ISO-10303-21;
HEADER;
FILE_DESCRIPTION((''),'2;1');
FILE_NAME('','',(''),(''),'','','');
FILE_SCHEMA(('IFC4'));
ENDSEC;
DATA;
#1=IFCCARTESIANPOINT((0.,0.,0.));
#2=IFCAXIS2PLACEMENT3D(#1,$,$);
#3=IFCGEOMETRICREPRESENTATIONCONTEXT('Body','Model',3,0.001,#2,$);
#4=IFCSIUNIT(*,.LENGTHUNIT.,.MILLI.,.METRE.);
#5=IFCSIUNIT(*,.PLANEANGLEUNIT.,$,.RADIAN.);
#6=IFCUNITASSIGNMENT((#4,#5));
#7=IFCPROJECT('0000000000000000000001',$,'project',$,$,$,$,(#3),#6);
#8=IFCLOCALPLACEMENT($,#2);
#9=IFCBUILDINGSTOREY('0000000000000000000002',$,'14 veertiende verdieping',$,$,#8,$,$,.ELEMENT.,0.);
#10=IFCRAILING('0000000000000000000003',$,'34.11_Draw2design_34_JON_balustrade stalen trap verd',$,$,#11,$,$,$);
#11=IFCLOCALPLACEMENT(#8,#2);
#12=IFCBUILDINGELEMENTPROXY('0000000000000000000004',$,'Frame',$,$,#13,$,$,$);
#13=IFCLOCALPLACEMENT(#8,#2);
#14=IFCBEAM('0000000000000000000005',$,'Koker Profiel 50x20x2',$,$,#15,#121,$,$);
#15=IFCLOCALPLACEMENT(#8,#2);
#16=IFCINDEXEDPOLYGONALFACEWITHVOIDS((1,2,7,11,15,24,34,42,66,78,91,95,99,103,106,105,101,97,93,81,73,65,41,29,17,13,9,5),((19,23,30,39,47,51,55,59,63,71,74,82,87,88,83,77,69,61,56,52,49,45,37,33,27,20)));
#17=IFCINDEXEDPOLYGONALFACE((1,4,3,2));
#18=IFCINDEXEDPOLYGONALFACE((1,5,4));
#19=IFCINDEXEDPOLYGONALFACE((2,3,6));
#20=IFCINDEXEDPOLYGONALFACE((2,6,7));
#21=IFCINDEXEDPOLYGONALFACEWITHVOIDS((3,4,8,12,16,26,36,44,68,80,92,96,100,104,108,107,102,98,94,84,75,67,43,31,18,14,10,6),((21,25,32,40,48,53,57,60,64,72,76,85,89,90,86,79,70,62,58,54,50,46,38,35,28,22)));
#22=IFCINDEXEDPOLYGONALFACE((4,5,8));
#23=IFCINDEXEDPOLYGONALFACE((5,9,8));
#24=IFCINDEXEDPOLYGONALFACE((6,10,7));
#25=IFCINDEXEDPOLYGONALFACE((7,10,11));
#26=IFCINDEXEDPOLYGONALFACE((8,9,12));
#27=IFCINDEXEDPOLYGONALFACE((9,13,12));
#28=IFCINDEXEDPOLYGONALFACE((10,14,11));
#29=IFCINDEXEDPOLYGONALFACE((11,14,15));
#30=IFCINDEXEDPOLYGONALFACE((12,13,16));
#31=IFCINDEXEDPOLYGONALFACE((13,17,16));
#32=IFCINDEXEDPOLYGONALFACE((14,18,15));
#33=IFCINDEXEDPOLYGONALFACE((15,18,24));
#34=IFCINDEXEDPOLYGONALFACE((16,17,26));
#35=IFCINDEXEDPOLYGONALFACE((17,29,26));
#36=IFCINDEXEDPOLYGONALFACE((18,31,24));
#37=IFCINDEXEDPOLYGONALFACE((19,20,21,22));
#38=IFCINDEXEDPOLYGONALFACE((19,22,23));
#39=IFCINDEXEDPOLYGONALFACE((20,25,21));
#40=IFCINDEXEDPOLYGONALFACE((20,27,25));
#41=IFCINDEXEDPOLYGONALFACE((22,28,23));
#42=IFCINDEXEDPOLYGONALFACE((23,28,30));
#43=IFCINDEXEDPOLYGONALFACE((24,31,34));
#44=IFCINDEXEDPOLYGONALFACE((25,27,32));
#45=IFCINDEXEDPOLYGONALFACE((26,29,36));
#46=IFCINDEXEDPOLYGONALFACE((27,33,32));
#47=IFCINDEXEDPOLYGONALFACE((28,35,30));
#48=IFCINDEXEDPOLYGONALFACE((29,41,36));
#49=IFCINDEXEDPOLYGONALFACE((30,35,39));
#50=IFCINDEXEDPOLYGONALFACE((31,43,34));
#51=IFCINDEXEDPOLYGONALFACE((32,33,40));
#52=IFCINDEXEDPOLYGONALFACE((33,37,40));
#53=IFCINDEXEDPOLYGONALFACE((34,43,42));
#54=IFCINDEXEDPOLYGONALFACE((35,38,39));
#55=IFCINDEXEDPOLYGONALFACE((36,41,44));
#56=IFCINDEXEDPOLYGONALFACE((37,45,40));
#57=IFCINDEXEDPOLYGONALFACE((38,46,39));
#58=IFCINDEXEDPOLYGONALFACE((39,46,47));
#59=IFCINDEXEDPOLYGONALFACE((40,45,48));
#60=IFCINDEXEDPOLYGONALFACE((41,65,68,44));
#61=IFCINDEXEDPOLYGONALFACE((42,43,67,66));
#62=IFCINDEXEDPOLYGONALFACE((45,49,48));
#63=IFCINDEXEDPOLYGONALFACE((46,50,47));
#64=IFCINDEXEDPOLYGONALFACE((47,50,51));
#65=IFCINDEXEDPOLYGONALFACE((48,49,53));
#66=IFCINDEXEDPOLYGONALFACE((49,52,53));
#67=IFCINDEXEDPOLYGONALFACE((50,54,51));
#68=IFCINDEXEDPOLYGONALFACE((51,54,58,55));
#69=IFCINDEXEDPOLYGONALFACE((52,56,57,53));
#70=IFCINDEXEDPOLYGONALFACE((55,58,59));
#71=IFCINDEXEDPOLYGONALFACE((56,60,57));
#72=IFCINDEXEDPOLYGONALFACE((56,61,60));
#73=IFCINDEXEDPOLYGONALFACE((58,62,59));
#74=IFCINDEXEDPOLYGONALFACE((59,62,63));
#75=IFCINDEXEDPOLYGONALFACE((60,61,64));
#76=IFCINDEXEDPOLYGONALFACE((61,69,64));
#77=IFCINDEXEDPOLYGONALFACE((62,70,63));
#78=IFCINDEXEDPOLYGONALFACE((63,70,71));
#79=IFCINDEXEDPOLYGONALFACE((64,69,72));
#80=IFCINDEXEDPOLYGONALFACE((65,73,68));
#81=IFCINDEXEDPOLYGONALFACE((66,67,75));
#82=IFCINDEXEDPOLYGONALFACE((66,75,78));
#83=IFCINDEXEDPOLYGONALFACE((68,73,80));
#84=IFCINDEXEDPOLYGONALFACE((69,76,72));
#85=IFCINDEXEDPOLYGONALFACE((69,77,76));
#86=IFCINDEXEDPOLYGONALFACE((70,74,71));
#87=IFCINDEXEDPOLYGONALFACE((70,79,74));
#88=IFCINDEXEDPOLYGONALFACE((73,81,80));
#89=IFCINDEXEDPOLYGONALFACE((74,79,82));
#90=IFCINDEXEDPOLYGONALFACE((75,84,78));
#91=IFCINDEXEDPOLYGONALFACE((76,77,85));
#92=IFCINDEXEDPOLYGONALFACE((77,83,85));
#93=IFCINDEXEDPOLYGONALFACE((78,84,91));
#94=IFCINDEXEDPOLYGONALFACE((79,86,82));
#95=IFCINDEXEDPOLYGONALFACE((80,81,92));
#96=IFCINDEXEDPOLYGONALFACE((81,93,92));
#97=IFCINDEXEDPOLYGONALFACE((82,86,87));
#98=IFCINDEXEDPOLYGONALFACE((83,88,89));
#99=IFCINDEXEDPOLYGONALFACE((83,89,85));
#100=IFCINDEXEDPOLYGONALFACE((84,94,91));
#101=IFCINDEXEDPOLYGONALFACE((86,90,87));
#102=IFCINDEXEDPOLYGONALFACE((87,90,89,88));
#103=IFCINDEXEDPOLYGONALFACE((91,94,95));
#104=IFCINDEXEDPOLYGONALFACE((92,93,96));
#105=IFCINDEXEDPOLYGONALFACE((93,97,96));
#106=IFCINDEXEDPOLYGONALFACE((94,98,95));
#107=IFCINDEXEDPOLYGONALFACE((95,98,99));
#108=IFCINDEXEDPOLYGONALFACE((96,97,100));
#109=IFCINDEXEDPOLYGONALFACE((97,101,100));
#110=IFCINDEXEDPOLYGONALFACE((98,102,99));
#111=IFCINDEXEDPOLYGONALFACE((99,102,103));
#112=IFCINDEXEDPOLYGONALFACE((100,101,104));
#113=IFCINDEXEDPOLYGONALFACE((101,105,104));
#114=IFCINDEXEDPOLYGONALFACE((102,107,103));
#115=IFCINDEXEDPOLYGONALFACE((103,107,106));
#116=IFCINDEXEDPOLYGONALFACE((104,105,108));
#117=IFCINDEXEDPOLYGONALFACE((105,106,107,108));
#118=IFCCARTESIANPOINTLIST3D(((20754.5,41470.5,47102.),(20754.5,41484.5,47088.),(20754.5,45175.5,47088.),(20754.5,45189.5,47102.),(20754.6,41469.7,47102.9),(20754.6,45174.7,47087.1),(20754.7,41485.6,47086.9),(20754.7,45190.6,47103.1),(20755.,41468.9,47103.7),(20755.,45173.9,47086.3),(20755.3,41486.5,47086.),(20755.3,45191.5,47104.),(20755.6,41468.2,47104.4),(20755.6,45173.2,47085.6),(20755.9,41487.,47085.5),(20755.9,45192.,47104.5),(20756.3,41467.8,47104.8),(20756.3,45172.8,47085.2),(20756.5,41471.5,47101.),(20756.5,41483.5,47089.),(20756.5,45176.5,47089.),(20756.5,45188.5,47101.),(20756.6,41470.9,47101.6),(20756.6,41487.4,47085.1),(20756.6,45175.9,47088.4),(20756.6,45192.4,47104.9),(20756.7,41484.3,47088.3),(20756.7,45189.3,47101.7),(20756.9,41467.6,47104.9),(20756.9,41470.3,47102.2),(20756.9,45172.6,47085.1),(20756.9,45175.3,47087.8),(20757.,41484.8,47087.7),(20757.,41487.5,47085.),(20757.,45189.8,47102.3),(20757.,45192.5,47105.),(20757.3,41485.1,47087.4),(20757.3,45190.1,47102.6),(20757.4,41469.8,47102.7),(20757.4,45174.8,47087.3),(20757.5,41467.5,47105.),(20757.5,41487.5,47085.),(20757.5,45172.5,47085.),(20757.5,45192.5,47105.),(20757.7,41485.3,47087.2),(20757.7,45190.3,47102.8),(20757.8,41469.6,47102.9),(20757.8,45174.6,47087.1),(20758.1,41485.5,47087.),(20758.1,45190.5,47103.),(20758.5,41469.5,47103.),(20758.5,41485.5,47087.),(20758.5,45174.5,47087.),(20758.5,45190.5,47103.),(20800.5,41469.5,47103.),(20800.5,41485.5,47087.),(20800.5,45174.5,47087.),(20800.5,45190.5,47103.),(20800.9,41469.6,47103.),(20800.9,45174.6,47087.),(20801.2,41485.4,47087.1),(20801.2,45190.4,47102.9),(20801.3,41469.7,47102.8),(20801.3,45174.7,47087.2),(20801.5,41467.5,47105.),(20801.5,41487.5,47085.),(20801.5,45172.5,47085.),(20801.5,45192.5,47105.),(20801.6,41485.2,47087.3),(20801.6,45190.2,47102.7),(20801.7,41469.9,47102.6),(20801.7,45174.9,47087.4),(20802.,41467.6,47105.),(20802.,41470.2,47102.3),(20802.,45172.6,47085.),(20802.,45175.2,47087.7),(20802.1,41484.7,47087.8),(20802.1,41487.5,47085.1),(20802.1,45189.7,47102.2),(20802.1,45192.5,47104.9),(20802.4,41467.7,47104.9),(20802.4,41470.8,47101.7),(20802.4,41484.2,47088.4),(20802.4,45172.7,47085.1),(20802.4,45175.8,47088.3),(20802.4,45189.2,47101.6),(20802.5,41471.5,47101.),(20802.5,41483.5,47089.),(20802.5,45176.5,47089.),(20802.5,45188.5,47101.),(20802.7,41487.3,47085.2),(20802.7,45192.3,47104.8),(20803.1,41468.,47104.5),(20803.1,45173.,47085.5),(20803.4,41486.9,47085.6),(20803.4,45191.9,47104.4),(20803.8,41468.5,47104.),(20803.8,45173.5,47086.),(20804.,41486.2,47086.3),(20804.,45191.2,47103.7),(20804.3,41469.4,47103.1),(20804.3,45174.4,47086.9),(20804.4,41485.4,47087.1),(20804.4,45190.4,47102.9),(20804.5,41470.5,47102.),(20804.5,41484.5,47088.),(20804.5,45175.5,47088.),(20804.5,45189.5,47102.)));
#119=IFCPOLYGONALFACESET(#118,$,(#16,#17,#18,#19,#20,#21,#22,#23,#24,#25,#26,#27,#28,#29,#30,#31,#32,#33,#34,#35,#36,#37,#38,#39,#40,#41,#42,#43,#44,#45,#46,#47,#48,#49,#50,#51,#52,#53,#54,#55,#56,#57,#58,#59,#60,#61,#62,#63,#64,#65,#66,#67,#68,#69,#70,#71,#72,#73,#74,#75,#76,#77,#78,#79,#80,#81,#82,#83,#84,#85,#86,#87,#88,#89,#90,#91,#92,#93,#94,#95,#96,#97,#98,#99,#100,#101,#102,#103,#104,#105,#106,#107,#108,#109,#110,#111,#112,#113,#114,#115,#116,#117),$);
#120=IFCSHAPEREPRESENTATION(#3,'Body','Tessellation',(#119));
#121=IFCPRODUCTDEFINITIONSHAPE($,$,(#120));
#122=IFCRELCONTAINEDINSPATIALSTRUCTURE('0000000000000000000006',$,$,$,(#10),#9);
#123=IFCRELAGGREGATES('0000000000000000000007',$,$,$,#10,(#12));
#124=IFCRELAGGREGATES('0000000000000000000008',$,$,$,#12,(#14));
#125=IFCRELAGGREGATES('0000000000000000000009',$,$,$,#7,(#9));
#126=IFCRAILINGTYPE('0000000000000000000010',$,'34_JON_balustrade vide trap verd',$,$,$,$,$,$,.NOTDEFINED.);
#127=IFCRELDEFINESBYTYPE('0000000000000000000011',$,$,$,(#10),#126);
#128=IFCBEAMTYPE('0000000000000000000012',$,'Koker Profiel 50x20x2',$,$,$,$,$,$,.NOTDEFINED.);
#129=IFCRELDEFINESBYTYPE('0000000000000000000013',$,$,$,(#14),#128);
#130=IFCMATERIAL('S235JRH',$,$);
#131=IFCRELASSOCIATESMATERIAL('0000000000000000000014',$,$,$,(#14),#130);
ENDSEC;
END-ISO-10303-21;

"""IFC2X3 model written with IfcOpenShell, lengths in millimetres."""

from ifc_helpers import new_model, si_unit, frame, origin, origin_2d, place, context, project, spatial, hollow_rectangle, extrude, clip, halfspace, source, transform, mapped, material, type_object, element, aggregate, save


model = new_model("IFC2X3")

# Units and contexts
model_context = context("Model", 3, precision=0.001, world=origin(), identifier="Body")
ifc_project = project(units=[si_unit("LENGTHUNIT", "METRE", prefix="MILLI"), si_unit("PLANEANGLEUNIT", "RADIAN")], contexts=[model_context])

# Storey
storey_placement = place(None, origin())
storey = spatial("IfcBuildingStorey", under=ifc_project, at=storey_placement, Name="14 veertiende verdieping", CompositionType="ELEMENT", Elevation=0.0)

# Railing, building element proxy, beam
railing_type = type_object("IfcRailingType", Name="34_JON_balustrade vide trap verd")
railing_placement = place(storey_placement, frame((-1939.6, -577.1, 100383.6)))
railing = element("IfcRailing", 1, at=railing_placement, inside=storey, type_object=railing_type, Name="34.11_Draw2design_34_JON_balustrade stalen trap verd")
proxy_1_placement = place(railing_placement, origin())
proxy_1 = element("IfcBuildingElementProxy", 2, at=proxy_1_placement, Name="Frame")
ifc_material_1 = material(Name="S235JRH")
beam_type_1 = type_object("IfcBeamType", Name="Koker Profiel 50x20x2")
aggregate(railing, [proxy_1])
shared_shape_1 = source(origin(), model_context, "Body", "Clipping", [
    clip(clip(extrude(hollow_rectangle(XDim=20.0, YDim=50.0, WallThickness=2.0, InnerFilletRadius=2.0, OuterFilletRadius=3.0, at=origin_2d()), origin(), (0.0, 0.0, -1.0), 3725.0), halfspace(frame((-4.1, -25.0, -5.9), z_axis=(0.707107, 0.0, 0.707107), x_axis=(0.707107, 0.0, -0.707107)), False)), halfspace(frame((-4.1, 25.0, -3719.1), z_axis=(0.707107, 0.0, -0.707107), x_axis=(-0.707107, 0.0, -0.707107)), False)),
])
beam_1_placement = place(proxy_1_placement, frame((22719.2, 42044.6, -53288.6), z_axis=(0.0, -1.0, 0.0), x_axis=(0.0, 0.0, -1.0)))
beam_1 = element("IfcBeam", 3, at=beam_1_placement, type_object=beam_type_1, material=ifc_material_1, Name="Koker Profiel 50x20x2", context=model_context, shape_type="MappedRepresentation", body=[
    mapped(shared_shape_1, transform((0.0, 0.0, 0.0), scale=1.0)),
])
aggregate(proxy_1, [beam_1])

save(model, "model.ifc")
